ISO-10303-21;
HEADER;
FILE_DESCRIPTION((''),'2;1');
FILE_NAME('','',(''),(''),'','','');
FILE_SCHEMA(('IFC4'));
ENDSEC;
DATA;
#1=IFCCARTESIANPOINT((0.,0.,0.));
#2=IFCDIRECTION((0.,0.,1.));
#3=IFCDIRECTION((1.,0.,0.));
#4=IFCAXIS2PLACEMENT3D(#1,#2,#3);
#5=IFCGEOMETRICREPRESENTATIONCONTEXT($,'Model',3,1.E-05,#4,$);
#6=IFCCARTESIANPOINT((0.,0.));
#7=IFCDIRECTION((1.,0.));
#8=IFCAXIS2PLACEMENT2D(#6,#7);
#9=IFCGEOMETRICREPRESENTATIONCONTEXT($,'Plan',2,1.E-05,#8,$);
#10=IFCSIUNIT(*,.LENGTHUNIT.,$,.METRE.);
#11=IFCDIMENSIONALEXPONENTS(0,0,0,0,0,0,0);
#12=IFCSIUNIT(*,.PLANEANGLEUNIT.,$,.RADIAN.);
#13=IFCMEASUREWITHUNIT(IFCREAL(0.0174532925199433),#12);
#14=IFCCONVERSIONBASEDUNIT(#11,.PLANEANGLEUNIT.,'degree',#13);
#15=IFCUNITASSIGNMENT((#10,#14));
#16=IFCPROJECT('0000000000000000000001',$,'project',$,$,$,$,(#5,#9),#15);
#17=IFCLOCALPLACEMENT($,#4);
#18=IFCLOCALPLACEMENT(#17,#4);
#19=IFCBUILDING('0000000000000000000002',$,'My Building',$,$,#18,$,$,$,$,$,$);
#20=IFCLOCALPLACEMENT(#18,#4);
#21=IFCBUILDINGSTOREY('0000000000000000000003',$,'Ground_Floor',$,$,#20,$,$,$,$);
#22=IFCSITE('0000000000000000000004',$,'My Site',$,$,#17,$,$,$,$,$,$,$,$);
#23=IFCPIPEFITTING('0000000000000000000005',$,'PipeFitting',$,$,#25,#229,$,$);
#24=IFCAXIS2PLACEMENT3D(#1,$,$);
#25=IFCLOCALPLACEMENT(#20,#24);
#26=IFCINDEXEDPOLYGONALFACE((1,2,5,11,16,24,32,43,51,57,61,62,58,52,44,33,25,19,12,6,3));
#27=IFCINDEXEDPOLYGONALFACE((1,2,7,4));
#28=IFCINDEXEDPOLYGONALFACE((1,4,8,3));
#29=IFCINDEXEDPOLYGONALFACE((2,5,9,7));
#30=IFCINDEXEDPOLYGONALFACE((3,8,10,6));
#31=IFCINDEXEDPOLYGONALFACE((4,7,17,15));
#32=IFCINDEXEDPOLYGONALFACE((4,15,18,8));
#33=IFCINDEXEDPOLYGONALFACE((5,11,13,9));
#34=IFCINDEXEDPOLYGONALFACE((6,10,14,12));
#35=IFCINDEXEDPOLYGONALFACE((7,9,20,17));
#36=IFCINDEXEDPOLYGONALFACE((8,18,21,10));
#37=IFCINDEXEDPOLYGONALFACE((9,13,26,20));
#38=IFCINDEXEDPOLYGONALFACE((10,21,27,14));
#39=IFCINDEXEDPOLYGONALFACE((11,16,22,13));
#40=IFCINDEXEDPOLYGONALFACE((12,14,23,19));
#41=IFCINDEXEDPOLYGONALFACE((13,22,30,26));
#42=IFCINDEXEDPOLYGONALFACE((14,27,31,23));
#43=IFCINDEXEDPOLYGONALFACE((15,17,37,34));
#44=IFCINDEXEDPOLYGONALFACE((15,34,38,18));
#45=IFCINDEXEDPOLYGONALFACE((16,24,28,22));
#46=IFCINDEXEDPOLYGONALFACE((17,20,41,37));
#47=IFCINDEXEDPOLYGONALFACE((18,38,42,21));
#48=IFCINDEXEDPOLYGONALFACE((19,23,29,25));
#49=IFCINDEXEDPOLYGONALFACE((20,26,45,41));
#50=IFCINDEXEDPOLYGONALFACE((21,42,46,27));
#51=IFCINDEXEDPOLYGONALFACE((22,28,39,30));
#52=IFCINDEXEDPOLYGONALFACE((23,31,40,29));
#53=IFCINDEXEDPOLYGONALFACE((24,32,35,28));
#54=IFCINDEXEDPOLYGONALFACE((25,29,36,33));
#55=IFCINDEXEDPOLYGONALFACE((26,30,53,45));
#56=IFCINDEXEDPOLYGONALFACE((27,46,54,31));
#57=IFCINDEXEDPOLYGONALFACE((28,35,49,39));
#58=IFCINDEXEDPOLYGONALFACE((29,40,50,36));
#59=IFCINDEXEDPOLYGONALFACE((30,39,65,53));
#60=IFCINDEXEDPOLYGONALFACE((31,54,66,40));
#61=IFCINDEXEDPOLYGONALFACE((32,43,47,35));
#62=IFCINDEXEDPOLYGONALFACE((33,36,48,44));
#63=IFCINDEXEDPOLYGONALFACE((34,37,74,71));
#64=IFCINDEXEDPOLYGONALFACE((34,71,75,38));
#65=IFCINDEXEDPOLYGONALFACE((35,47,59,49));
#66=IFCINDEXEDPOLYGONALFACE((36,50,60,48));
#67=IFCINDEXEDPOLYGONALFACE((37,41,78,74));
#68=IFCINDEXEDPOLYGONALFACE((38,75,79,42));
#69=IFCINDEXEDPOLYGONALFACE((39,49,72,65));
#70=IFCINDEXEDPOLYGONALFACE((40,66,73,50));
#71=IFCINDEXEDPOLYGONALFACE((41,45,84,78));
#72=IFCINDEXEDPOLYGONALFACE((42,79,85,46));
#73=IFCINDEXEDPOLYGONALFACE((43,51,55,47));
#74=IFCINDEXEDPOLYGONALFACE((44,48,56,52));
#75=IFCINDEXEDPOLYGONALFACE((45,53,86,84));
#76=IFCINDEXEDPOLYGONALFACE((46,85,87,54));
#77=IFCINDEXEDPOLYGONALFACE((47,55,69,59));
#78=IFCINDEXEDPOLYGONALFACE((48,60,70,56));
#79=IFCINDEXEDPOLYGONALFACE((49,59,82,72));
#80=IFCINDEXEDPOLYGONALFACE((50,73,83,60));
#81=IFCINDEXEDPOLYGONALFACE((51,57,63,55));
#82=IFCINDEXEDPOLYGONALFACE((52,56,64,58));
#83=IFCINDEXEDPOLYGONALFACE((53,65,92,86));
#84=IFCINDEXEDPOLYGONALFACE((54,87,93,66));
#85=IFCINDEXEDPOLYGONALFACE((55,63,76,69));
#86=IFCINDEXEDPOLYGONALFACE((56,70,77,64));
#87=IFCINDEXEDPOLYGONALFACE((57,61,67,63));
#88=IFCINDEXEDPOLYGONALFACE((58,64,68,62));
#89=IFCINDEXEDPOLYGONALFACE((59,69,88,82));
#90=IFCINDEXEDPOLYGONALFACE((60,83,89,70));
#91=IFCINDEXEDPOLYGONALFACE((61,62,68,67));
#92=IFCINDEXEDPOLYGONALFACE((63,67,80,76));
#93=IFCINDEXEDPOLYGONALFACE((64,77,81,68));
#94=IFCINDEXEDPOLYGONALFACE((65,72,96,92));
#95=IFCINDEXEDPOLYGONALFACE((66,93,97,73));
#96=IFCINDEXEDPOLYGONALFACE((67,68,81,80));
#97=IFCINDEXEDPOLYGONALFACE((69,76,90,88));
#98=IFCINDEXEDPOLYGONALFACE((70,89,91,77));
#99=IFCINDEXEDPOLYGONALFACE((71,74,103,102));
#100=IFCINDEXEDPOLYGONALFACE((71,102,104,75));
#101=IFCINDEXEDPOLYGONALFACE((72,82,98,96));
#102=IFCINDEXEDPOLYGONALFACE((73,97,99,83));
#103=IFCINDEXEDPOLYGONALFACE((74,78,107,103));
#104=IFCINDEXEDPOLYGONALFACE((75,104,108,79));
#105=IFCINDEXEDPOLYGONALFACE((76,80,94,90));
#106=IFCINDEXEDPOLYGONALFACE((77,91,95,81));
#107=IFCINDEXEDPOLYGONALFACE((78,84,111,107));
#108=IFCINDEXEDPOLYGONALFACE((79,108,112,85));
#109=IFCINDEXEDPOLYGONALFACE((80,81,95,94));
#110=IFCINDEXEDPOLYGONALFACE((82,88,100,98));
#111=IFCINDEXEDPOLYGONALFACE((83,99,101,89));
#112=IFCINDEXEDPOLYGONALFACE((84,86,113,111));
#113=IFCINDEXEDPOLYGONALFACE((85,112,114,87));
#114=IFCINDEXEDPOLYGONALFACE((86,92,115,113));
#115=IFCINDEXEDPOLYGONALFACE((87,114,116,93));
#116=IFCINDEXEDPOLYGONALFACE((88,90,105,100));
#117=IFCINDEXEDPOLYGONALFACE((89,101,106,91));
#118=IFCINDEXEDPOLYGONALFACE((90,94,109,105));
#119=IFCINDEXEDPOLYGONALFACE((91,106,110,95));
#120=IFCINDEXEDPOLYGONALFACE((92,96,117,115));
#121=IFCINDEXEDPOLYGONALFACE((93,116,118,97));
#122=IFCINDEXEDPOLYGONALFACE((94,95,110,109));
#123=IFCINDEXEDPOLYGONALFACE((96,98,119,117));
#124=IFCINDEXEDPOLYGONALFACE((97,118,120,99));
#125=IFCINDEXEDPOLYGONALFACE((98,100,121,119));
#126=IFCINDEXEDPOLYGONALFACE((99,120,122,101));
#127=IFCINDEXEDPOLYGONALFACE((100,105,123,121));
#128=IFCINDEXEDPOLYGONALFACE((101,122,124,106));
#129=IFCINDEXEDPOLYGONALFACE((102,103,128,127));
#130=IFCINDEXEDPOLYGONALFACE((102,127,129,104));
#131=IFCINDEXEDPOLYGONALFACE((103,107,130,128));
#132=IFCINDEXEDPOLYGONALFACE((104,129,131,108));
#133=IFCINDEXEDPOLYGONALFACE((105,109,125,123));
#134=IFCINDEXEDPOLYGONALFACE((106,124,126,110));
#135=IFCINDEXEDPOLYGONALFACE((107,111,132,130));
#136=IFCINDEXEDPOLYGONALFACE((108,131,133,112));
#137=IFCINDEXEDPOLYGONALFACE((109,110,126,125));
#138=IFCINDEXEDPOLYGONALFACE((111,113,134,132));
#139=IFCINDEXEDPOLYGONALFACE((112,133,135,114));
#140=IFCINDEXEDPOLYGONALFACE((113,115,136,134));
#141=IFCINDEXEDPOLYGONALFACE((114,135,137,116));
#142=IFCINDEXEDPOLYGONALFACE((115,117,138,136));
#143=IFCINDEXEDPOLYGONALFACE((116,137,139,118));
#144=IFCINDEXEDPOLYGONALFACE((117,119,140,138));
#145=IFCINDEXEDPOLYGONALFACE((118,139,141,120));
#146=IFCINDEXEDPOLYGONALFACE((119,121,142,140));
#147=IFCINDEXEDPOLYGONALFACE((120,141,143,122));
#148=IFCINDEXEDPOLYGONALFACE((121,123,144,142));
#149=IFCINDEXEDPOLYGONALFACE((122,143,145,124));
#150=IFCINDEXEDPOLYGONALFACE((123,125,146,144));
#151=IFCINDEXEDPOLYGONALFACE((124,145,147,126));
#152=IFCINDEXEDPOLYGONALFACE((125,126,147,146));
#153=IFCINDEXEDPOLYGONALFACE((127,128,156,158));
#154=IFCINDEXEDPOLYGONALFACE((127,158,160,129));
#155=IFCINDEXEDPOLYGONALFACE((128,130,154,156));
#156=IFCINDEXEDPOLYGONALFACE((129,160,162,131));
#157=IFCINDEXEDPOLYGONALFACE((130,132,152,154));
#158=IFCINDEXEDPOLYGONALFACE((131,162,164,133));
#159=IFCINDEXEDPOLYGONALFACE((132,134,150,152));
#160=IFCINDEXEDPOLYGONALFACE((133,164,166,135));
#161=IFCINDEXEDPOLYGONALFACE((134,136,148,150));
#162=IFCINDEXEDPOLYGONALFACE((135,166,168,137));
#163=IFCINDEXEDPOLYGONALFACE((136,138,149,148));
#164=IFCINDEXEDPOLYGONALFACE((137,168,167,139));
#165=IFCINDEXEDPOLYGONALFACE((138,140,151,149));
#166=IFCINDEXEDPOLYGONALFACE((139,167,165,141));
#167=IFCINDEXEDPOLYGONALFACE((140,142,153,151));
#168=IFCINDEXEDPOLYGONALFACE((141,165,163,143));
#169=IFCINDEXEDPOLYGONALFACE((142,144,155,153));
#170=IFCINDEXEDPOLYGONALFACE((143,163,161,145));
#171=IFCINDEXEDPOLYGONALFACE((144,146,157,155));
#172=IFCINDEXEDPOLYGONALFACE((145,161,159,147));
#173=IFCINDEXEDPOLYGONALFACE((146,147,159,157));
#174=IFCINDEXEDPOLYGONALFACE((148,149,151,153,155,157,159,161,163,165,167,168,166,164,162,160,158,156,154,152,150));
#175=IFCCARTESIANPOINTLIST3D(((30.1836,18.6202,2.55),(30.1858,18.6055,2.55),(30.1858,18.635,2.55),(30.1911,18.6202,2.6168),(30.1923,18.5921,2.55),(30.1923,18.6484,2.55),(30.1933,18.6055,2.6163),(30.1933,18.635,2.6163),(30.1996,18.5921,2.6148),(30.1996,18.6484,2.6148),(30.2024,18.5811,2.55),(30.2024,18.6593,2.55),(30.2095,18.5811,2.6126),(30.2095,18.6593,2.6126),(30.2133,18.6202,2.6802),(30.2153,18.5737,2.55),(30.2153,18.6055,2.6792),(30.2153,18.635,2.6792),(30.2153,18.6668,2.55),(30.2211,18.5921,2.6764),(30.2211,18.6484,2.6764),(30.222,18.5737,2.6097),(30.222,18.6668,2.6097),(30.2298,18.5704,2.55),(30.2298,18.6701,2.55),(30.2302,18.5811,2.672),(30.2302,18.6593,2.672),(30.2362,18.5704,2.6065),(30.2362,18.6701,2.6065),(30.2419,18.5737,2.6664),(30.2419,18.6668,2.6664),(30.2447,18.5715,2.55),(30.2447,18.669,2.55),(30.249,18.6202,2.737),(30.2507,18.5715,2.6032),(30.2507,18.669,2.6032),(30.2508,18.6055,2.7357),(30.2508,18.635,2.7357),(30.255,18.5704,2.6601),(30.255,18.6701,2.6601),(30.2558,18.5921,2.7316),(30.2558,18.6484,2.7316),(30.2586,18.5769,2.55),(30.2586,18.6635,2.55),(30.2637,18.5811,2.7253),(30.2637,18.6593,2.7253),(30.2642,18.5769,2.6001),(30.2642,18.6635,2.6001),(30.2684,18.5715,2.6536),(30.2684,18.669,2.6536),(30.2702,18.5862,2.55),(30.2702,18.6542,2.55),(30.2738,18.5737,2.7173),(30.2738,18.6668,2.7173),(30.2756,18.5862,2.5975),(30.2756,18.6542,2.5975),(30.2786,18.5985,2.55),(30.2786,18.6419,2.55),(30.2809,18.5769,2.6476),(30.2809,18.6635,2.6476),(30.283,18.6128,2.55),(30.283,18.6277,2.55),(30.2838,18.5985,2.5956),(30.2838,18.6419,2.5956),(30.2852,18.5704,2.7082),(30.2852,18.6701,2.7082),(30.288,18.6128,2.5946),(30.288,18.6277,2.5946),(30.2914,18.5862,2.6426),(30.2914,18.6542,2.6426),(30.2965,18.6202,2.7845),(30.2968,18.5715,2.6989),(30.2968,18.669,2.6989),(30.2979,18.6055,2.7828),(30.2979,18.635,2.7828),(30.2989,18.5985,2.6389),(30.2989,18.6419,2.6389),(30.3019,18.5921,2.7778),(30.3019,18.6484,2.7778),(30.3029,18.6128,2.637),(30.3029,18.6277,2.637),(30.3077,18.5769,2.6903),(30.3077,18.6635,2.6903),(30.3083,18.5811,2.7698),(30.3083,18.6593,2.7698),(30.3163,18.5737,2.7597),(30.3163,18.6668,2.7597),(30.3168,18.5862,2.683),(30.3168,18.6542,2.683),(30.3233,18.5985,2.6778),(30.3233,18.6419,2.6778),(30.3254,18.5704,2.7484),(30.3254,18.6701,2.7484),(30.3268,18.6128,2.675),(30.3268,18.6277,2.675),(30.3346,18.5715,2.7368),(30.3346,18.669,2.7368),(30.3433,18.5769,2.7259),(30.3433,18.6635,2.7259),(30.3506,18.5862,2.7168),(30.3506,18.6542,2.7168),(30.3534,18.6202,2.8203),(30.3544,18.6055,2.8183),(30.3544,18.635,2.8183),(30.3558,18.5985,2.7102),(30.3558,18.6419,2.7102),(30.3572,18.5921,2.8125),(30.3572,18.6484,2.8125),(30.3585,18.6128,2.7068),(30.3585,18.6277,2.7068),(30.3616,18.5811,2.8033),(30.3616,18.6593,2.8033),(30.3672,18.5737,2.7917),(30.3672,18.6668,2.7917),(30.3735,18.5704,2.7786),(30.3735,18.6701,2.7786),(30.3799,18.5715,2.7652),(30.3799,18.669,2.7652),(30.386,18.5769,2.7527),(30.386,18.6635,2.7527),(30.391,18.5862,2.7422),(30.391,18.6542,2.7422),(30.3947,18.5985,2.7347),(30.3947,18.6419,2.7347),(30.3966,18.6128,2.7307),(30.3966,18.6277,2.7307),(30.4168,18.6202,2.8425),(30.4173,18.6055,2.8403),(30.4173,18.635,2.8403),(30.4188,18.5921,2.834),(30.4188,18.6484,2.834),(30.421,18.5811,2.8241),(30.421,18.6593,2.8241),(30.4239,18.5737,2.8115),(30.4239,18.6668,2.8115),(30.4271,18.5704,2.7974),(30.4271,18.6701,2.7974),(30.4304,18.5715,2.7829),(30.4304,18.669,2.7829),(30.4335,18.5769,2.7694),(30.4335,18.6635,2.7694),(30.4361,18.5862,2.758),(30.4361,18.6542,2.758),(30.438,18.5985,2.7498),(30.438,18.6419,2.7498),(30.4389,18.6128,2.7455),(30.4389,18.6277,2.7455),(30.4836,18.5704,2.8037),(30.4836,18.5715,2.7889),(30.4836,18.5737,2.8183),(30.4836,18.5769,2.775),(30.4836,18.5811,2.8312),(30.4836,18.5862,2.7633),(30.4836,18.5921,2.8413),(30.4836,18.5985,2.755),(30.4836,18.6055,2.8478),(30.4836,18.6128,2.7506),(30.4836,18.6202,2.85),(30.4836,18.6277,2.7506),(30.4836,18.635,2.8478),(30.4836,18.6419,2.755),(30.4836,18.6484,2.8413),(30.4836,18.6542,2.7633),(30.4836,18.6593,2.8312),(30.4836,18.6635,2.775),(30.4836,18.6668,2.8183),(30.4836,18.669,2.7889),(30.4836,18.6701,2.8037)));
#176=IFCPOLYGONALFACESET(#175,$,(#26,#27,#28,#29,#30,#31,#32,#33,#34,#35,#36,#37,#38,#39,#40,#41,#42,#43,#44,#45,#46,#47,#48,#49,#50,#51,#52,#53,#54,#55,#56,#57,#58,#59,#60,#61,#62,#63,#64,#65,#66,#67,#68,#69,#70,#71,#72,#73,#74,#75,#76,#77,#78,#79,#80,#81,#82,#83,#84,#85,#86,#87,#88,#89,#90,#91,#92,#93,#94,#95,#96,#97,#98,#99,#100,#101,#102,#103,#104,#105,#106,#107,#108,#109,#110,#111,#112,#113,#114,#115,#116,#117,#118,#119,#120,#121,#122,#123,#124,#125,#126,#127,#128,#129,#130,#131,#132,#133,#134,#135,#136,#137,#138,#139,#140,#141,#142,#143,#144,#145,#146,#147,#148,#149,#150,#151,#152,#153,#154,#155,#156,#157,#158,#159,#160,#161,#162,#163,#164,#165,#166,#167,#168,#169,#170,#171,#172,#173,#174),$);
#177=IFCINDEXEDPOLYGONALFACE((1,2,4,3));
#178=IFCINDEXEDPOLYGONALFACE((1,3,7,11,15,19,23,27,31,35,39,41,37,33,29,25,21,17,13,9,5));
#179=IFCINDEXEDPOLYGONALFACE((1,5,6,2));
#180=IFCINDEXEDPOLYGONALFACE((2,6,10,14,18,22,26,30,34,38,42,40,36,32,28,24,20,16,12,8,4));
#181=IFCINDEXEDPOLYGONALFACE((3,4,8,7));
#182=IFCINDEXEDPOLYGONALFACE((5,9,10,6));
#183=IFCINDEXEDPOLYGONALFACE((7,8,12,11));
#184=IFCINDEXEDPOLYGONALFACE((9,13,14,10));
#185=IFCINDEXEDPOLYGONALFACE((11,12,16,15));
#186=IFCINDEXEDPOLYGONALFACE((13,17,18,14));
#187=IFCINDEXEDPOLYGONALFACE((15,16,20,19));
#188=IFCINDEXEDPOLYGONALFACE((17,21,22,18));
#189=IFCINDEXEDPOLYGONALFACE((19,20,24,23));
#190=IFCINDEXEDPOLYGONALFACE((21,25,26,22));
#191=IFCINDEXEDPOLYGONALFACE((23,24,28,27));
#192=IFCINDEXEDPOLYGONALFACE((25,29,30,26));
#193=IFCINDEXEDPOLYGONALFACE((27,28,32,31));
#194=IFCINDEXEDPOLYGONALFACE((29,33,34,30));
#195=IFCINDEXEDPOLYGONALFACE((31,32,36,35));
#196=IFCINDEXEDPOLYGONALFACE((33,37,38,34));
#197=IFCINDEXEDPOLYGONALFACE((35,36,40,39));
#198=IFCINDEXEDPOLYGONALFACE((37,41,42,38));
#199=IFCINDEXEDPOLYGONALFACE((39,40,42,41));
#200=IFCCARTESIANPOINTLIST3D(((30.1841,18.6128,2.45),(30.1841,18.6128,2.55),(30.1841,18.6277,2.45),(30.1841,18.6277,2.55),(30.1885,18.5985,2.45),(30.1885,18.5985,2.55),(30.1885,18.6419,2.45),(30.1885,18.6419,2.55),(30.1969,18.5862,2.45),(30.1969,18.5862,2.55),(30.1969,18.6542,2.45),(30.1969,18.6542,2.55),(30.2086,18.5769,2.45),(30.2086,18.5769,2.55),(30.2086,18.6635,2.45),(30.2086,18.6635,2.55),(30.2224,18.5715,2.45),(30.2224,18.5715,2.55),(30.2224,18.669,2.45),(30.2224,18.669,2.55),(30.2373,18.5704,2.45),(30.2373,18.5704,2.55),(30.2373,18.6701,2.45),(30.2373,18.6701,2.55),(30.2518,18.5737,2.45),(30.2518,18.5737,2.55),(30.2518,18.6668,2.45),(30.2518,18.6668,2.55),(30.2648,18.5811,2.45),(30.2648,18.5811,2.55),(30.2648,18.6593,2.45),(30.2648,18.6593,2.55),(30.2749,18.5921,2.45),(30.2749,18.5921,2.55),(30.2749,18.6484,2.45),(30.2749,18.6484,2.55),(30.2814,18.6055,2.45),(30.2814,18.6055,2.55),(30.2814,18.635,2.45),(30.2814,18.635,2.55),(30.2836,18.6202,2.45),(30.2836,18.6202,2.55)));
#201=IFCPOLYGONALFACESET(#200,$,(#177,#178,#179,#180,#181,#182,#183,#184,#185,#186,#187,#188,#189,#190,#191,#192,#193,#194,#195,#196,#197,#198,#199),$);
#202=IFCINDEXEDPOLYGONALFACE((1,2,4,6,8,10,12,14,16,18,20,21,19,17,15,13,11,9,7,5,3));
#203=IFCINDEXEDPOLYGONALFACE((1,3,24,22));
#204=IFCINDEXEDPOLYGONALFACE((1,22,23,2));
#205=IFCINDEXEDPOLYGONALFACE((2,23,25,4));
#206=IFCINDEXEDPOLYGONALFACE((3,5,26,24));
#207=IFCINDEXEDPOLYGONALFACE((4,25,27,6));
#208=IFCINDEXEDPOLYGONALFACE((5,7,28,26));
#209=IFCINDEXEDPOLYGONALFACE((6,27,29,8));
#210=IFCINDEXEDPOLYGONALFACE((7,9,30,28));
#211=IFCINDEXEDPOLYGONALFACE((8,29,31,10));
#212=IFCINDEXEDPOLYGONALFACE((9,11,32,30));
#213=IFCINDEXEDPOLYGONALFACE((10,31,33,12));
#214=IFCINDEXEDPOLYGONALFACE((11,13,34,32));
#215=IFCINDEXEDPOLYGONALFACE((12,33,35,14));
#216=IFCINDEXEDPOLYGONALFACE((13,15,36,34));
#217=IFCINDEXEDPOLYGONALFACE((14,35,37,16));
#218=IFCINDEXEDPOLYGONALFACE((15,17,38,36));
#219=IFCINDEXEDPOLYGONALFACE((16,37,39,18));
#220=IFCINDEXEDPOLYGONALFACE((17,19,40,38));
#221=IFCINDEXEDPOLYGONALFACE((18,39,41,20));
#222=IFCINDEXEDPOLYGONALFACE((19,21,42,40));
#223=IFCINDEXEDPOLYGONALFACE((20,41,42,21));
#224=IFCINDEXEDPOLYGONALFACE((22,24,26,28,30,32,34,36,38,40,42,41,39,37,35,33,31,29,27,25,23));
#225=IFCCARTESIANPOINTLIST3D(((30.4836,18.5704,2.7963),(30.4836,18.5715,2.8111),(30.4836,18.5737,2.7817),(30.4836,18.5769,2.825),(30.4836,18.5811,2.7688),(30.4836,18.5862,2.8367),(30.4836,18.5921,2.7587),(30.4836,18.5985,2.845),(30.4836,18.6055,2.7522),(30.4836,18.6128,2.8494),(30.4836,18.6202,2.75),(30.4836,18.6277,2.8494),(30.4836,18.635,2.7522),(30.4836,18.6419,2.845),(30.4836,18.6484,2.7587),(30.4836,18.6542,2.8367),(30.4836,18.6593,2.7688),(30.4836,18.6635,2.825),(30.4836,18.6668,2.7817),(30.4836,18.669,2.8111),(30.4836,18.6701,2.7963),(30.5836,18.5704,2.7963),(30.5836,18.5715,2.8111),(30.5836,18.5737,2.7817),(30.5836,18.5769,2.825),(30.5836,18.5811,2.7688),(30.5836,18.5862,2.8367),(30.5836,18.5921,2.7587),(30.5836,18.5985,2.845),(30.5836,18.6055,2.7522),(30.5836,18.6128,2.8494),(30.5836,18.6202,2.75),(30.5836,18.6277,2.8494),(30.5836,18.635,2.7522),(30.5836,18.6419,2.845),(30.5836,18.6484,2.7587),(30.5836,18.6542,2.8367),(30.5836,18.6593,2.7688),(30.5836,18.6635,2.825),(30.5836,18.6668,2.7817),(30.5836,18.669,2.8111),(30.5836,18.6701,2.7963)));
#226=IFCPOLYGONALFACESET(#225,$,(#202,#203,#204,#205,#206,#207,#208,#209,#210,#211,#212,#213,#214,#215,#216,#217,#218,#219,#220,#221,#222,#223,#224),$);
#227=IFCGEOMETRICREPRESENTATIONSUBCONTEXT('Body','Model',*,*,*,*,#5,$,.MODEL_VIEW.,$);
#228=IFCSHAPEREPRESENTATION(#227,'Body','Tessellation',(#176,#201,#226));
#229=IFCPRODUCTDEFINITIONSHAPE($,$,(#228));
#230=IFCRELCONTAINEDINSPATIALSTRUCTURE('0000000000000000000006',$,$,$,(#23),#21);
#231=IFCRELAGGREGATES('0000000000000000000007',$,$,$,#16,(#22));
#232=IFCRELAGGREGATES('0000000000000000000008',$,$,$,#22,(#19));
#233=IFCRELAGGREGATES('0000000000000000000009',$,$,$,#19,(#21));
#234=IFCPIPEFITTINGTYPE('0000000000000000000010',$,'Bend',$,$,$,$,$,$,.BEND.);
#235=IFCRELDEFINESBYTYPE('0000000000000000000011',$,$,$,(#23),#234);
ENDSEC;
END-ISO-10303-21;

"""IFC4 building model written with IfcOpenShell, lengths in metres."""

from ifc_helpers import new_model, entity, si_unit, converted_unit, frame, origin_with_axes, origin_2d_with_axis, place, context, subcontext, project, spatial, circle, extrude, source, transform, mapped, type_object, type_shapes, element, save


model = new_model("IFC4")

# Units and contexts
model_context = context("Model", 3, precision=1e-05, world=origin_with_axes())
plan_context = context("Plan", 2, precision=1e-05, world=origin_2d_with_axis())
body_context = subcontext(model_context, "Body", "Model", "MODEL_VIEW")
ifc_project = project(units=[si_unit("LENGTHUNIT", "METRE"), converted_unit("PLANEANGLEUNIT", "degree", entity("IfcReal", 0.0174532925199433), si_unit("PLANEANGLEUNIT", "RADIAN"), dimensions=[0, 0, 0, 0, 0, 0, 0])], contexts=[model_context, plan_context])

# Site, building, storey
site_placement = place(None, origin_with_axes())
site = spatial("IfcSite", under=ifc_project, at=site_placement, Name="My Site")
building_placement = place(site_placement, origin_with_axes())
building = spatial("IfcBuilding", under=site, at=building_placement, Name="My Building")
storey_placement = place(building_placement, origin_with_axes())
storey = spatial("IfcBuildingStorey", under=building, at=storey_placement, Name="Ground_Floor")

# Pipe fitting
pipe_fitting_type = type_object("IfcPipeFittingType", Name="Bend", PredefinedType="BEND")
shared_shape = source(origin_with_axes(), body_context, "Body", "SolidModel", [
    entity("IfcSweptDiskSolid", entity("IfcIndexedPolyCurve", entity("IfcCartesianPointList3D", [[0.0, 0.0, -0.1], [0.0732, 0.0, -0.2768], [0.25, 0.0, -0.35]]), [entity("IfcArcIndex", [1, 2, 3])]), 0.05),
    extrude(circle(Radius=0.05), origin_with_axes(), (0.0, 0.0, -1.0), 0.1),
    extrude(circle(Radius=0.05), frame((0.25, 0.0, -0.35), z_axis=(1.0, 0.0, 0.0), x_axis=(0.0, 0.0, 1.0)), (0.0, 0.0, 1.0), 0.1),
])
type_shapes(pipe_fitting_type, [shared_shape])
for number, where, z_axis, x_axis, name in (
    (1, (30.2336, 18.6202, 2.45), (0.0, 0.0, -1.0), (1.0, 0.0, 0.0), "PipeFitting"),
):
    element("IfcPipeFitting", number, at=place(storey_placement, frame(where, z_axis=z_axis, x_axis=x_axis)), inside=storey, type_object=pipe_fitting_type, Name=name, context=body_context, shape_type="MappedRepresentation", body=[
        mapped(shared_shape, transform((0.0, 0.0, 0.0), x_axis=(1.0, 0.0, 0.0), y_axis=(0.0, 1.0, 0.0), z_axis=(0.0, 0.0, 1.0), scale=1.0)),
    ])

save(model, "model.ifc")
